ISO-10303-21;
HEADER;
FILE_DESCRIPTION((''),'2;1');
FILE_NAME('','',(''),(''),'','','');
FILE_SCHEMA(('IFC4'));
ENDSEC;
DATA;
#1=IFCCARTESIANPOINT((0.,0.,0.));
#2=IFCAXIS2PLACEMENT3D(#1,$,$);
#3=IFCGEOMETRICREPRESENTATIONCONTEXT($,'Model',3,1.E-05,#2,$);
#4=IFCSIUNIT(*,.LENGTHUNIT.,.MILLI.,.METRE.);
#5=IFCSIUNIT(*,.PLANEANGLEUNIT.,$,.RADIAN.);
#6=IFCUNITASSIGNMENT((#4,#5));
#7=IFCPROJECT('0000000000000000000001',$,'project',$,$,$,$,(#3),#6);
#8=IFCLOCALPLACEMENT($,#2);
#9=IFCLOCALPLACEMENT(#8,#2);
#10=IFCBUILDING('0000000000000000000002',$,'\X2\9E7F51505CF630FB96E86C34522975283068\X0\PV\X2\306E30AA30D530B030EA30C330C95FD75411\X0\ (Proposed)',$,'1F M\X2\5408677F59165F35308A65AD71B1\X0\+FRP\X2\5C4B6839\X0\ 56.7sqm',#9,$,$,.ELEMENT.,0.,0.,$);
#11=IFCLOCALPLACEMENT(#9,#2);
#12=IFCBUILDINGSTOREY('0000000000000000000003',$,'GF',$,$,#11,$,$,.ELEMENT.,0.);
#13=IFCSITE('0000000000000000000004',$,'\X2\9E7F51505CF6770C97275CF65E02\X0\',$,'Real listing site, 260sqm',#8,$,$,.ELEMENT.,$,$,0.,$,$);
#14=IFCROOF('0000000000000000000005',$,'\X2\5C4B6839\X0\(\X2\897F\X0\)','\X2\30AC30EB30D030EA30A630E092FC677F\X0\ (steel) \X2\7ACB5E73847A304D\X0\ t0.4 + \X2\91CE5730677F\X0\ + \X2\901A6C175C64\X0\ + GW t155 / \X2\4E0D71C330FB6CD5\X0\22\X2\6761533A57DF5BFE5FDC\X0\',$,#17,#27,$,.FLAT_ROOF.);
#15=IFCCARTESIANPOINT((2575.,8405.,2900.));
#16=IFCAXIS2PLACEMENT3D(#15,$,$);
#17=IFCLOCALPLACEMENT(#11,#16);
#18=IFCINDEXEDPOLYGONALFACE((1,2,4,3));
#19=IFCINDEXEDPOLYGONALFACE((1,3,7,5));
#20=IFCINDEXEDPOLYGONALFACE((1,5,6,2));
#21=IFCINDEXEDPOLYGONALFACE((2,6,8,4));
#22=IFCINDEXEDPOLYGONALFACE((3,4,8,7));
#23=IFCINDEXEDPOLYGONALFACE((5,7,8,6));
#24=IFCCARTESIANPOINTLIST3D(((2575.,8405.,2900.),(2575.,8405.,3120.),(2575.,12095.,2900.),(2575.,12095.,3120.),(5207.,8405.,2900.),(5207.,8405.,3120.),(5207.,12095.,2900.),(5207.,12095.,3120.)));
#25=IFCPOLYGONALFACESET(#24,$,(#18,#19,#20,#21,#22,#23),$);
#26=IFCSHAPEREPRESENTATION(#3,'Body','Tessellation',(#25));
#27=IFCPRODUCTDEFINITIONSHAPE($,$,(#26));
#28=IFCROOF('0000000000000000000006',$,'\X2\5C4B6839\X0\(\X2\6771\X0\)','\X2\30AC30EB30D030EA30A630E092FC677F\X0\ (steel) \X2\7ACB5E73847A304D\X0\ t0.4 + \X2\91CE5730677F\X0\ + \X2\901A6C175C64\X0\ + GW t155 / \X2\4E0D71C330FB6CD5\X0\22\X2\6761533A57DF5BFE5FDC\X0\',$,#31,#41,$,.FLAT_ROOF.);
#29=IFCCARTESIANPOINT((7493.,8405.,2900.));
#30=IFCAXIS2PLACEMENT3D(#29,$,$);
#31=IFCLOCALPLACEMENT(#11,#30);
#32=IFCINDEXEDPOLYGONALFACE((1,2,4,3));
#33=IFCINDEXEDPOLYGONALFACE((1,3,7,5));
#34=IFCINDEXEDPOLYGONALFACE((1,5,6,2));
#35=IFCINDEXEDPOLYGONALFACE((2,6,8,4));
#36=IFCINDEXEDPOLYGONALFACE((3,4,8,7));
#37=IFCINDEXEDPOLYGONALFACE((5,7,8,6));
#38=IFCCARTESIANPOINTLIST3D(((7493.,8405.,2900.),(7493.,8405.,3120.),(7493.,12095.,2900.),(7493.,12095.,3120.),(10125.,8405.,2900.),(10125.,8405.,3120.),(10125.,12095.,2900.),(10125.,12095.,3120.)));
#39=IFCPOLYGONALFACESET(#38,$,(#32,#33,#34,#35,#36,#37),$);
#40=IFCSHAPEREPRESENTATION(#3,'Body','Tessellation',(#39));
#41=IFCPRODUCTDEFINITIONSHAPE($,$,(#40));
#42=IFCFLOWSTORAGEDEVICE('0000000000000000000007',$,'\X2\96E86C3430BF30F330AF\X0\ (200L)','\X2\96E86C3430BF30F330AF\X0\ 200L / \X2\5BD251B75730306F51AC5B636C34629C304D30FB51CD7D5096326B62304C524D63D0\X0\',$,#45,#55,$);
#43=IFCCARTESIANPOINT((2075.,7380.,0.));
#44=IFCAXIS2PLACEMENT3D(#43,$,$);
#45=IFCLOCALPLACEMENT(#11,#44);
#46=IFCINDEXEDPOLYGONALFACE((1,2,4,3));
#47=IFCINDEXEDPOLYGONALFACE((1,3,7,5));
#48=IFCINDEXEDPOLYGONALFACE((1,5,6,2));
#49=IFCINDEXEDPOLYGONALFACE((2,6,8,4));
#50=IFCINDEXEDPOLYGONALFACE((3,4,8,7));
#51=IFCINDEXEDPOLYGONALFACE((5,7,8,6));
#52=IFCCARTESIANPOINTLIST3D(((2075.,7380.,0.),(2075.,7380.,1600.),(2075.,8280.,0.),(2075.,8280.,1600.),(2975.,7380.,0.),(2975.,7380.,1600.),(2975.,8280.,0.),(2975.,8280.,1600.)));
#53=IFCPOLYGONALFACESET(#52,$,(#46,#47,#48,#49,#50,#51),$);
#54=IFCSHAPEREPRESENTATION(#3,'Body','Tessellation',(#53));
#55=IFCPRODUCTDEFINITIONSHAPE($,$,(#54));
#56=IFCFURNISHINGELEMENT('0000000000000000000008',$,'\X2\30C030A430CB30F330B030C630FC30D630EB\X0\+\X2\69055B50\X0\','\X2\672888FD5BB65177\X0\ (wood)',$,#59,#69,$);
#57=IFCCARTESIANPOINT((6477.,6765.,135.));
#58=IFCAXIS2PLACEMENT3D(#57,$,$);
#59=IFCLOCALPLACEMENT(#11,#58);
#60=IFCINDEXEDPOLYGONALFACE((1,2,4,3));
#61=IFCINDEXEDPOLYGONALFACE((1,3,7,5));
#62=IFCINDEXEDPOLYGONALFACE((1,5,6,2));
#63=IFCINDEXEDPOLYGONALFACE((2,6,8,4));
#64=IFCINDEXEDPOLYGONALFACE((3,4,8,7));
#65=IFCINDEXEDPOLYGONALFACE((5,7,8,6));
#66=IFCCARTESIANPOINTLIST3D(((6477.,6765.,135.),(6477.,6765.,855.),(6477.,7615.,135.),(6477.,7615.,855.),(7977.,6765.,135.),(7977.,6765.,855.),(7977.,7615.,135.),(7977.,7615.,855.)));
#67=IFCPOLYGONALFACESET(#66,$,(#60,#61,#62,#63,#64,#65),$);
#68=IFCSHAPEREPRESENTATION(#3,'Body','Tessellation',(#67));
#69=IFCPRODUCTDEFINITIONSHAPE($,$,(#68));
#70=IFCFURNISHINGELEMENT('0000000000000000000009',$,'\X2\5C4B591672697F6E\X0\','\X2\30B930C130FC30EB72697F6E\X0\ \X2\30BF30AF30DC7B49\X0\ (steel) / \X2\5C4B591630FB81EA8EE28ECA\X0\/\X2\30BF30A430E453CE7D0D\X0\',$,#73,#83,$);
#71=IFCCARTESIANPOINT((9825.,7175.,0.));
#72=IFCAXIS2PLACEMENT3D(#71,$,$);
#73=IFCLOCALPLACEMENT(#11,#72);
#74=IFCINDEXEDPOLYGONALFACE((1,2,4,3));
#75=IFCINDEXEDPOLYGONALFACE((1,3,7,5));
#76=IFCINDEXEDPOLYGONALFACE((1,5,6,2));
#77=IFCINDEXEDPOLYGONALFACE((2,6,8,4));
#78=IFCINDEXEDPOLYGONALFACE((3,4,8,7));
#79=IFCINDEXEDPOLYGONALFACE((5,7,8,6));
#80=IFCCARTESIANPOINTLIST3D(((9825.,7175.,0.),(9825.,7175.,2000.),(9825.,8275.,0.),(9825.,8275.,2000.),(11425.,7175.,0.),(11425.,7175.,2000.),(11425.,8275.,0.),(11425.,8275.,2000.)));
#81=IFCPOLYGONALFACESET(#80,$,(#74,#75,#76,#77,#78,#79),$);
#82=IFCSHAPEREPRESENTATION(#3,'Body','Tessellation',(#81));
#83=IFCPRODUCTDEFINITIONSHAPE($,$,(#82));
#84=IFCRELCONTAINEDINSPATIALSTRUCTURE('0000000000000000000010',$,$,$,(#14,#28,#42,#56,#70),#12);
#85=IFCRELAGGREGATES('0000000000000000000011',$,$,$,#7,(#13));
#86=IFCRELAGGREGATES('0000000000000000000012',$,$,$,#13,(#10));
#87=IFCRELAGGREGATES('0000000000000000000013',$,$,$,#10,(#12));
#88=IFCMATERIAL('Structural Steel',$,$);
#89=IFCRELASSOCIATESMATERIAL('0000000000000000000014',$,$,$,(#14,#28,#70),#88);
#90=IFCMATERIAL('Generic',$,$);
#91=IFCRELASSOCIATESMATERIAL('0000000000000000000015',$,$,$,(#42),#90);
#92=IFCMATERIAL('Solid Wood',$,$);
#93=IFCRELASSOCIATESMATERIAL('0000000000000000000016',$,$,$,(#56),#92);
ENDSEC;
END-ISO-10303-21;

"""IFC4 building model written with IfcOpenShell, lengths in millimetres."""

from ifc_helpers import new_model, si_unit, frame, frame_2d, origin, place, context, project, spatial, rectangle, extrude, material, element, save


model = new_model("IFC4")

# Units and contexts
model_context = context("Model", 3, precision=1e-05, world=origin())
ifc_project = project(units=[si_unit("LENGTHUNIT", "METRE", prefix="MILLI"), si_unit("PLANEANGLEUNIT", "RADIAN")], contexts=[model_context])

# Site, building, storey
site_placement = place(None, origin())
site = spatial("IfcSite", under=ifc_project, at=site_placement, Name="鹿児島県霧島市", ObjectType="Real listing site, 260sqm", CompositionType="ELEMENT", RefElevation=0.0)
building_placement = place(site_placement, origin())
building = spatial("IfcBuilding", under=site, at=building_placement, Name="鹿児島・雨水利用とPVのオフグリッド志向 (Proposed)", ObjectType="1F M合板外張り断熱+FRP屋根 56.7sqm", CompositionType="ELEMENT", ElevationOfRefHeight=0.0, ElevationOfTerrain=0.0)
storey_placement = place(building_placement, origin())
storey = spatial("IfcBuildingStorey", under=building, at=storey_placement, Name="GF", CompositionType="ELEMENT", Elevation=0.0)

# Shared definitions
ifc_material_1 = material(Name="Solid Wood")

# Roofs
ifc_material_2 = material(Name="Structural Steel")
roof_1_placement = place(storey_placement, frame((2575.0, 8405.0, 2900.0)))
element("IfcRoof", 1, at=roof_1_placement, inside=storey, material=ifc_material_2, Name="屋根(西)", Description="ガルバリウム鋼板 (steel) 立平葺き t0.4 + 野地板 + 通気層 + GW t155 / 不燃・法22条区域対応", PredefinedType="FLAT_ROOF", context=model_context, shape_type="SweptSolid", body=[
    extrude(rectangle(XDim=2632.0, YDim=3690.0, at=frame_2d((1316.0, 1845.0))), frame((2575.0, 8405.0, 2900.0)), (0.0, 0.0, 1.0), 220.0),
])
roof_2_placement = place(storey_placement, frame((7493.0, 8405.0, 2900.0)))
element("IfcRoof", 2, at=roof_2_placement, inside=storey, material=ifc_material_2, Name="屋根(東)", Description="ガルバリウム鋼板 (steel) 立平葺き t0.4 + 野地板 + 通気層 + GW t155 / 不燃・法22条区域対応", PredefinedType="FLAT_ROOF", context=model_context, shape_type="SweptSolid", body=[
    extrude(rectangle(XDim=2632.0, YDim=3690.0, at=frame_2d((1316.0, 1845.0))), frame((7493.0, 8405.0, 2900.0)), (0.0, 0.0, 1.0), 220.0),
])

# Flow storage device
ifc_material_3 = material(Name="Generic")
flow_storage_device_placement = place(storey_placement, frame((2075.0, 7380.0, 0.0)))
element("IfcFlowStorageDevice", 3, at=flow_storage_device_placement, inside=storey, material=ifc_material_3, Name="雨水タンク (200L)", Description="雨水タンク 200L / 寒冷地は冬季水抜き・凍結防止が前提", context=model_context, shape_type="SweptSolid", body=[
    extrude(rectangle(XDim=900.0, YDim=900.0, at=frame_2d((450.0, 450.0))), frame((2075.0, 7380.0, 0.0)), (0.0, 0.0, 1.0), 1600.0),
])

# Furnishing elements
furnishing_1_placement = place(storey_placement, frame((6477.0, 6765.0, 135.0)))
element("IfcFurnishingElement", 4, at=furnishing_1_placement, inside=storey, material=ifc_material_1, Name="ダイニングテーブル+椅子", Description="木製家具 (wood)", context=model_context, shape_type="SweptSolid", body=[
    extrude(rectangle(XDim=1500.0, YDim=850.0, at=frame_2d((750.0, 425.0))), frame((6477.0, 6765.0, 135.0)), (0.0, 0.0, 1.0), 720.0),
])
furnishing_2_placement = place(storey_placement, frame((9825.0, 7175.0, 0.0)))
element("IfcFurnishingElement", 5, at=furnishing_2_placement, inside=storey, material=ifc_material_2, Name="屋外物置", Description="スチール物置 タクボ等 (steel) / 屋外・自転車/タイヤ収納", context=model_context, shape_type="SweptSolid", body=[
    extrude(rectangle(XDim=1600.0, YDim=1100.0, at=frame_2d((800.0, 550.0))), frame((9825.0, 7175.0, 0.0)), (0.0, 0.0, 1.0), 2000.0),
])

save(model, "model.ifc")
